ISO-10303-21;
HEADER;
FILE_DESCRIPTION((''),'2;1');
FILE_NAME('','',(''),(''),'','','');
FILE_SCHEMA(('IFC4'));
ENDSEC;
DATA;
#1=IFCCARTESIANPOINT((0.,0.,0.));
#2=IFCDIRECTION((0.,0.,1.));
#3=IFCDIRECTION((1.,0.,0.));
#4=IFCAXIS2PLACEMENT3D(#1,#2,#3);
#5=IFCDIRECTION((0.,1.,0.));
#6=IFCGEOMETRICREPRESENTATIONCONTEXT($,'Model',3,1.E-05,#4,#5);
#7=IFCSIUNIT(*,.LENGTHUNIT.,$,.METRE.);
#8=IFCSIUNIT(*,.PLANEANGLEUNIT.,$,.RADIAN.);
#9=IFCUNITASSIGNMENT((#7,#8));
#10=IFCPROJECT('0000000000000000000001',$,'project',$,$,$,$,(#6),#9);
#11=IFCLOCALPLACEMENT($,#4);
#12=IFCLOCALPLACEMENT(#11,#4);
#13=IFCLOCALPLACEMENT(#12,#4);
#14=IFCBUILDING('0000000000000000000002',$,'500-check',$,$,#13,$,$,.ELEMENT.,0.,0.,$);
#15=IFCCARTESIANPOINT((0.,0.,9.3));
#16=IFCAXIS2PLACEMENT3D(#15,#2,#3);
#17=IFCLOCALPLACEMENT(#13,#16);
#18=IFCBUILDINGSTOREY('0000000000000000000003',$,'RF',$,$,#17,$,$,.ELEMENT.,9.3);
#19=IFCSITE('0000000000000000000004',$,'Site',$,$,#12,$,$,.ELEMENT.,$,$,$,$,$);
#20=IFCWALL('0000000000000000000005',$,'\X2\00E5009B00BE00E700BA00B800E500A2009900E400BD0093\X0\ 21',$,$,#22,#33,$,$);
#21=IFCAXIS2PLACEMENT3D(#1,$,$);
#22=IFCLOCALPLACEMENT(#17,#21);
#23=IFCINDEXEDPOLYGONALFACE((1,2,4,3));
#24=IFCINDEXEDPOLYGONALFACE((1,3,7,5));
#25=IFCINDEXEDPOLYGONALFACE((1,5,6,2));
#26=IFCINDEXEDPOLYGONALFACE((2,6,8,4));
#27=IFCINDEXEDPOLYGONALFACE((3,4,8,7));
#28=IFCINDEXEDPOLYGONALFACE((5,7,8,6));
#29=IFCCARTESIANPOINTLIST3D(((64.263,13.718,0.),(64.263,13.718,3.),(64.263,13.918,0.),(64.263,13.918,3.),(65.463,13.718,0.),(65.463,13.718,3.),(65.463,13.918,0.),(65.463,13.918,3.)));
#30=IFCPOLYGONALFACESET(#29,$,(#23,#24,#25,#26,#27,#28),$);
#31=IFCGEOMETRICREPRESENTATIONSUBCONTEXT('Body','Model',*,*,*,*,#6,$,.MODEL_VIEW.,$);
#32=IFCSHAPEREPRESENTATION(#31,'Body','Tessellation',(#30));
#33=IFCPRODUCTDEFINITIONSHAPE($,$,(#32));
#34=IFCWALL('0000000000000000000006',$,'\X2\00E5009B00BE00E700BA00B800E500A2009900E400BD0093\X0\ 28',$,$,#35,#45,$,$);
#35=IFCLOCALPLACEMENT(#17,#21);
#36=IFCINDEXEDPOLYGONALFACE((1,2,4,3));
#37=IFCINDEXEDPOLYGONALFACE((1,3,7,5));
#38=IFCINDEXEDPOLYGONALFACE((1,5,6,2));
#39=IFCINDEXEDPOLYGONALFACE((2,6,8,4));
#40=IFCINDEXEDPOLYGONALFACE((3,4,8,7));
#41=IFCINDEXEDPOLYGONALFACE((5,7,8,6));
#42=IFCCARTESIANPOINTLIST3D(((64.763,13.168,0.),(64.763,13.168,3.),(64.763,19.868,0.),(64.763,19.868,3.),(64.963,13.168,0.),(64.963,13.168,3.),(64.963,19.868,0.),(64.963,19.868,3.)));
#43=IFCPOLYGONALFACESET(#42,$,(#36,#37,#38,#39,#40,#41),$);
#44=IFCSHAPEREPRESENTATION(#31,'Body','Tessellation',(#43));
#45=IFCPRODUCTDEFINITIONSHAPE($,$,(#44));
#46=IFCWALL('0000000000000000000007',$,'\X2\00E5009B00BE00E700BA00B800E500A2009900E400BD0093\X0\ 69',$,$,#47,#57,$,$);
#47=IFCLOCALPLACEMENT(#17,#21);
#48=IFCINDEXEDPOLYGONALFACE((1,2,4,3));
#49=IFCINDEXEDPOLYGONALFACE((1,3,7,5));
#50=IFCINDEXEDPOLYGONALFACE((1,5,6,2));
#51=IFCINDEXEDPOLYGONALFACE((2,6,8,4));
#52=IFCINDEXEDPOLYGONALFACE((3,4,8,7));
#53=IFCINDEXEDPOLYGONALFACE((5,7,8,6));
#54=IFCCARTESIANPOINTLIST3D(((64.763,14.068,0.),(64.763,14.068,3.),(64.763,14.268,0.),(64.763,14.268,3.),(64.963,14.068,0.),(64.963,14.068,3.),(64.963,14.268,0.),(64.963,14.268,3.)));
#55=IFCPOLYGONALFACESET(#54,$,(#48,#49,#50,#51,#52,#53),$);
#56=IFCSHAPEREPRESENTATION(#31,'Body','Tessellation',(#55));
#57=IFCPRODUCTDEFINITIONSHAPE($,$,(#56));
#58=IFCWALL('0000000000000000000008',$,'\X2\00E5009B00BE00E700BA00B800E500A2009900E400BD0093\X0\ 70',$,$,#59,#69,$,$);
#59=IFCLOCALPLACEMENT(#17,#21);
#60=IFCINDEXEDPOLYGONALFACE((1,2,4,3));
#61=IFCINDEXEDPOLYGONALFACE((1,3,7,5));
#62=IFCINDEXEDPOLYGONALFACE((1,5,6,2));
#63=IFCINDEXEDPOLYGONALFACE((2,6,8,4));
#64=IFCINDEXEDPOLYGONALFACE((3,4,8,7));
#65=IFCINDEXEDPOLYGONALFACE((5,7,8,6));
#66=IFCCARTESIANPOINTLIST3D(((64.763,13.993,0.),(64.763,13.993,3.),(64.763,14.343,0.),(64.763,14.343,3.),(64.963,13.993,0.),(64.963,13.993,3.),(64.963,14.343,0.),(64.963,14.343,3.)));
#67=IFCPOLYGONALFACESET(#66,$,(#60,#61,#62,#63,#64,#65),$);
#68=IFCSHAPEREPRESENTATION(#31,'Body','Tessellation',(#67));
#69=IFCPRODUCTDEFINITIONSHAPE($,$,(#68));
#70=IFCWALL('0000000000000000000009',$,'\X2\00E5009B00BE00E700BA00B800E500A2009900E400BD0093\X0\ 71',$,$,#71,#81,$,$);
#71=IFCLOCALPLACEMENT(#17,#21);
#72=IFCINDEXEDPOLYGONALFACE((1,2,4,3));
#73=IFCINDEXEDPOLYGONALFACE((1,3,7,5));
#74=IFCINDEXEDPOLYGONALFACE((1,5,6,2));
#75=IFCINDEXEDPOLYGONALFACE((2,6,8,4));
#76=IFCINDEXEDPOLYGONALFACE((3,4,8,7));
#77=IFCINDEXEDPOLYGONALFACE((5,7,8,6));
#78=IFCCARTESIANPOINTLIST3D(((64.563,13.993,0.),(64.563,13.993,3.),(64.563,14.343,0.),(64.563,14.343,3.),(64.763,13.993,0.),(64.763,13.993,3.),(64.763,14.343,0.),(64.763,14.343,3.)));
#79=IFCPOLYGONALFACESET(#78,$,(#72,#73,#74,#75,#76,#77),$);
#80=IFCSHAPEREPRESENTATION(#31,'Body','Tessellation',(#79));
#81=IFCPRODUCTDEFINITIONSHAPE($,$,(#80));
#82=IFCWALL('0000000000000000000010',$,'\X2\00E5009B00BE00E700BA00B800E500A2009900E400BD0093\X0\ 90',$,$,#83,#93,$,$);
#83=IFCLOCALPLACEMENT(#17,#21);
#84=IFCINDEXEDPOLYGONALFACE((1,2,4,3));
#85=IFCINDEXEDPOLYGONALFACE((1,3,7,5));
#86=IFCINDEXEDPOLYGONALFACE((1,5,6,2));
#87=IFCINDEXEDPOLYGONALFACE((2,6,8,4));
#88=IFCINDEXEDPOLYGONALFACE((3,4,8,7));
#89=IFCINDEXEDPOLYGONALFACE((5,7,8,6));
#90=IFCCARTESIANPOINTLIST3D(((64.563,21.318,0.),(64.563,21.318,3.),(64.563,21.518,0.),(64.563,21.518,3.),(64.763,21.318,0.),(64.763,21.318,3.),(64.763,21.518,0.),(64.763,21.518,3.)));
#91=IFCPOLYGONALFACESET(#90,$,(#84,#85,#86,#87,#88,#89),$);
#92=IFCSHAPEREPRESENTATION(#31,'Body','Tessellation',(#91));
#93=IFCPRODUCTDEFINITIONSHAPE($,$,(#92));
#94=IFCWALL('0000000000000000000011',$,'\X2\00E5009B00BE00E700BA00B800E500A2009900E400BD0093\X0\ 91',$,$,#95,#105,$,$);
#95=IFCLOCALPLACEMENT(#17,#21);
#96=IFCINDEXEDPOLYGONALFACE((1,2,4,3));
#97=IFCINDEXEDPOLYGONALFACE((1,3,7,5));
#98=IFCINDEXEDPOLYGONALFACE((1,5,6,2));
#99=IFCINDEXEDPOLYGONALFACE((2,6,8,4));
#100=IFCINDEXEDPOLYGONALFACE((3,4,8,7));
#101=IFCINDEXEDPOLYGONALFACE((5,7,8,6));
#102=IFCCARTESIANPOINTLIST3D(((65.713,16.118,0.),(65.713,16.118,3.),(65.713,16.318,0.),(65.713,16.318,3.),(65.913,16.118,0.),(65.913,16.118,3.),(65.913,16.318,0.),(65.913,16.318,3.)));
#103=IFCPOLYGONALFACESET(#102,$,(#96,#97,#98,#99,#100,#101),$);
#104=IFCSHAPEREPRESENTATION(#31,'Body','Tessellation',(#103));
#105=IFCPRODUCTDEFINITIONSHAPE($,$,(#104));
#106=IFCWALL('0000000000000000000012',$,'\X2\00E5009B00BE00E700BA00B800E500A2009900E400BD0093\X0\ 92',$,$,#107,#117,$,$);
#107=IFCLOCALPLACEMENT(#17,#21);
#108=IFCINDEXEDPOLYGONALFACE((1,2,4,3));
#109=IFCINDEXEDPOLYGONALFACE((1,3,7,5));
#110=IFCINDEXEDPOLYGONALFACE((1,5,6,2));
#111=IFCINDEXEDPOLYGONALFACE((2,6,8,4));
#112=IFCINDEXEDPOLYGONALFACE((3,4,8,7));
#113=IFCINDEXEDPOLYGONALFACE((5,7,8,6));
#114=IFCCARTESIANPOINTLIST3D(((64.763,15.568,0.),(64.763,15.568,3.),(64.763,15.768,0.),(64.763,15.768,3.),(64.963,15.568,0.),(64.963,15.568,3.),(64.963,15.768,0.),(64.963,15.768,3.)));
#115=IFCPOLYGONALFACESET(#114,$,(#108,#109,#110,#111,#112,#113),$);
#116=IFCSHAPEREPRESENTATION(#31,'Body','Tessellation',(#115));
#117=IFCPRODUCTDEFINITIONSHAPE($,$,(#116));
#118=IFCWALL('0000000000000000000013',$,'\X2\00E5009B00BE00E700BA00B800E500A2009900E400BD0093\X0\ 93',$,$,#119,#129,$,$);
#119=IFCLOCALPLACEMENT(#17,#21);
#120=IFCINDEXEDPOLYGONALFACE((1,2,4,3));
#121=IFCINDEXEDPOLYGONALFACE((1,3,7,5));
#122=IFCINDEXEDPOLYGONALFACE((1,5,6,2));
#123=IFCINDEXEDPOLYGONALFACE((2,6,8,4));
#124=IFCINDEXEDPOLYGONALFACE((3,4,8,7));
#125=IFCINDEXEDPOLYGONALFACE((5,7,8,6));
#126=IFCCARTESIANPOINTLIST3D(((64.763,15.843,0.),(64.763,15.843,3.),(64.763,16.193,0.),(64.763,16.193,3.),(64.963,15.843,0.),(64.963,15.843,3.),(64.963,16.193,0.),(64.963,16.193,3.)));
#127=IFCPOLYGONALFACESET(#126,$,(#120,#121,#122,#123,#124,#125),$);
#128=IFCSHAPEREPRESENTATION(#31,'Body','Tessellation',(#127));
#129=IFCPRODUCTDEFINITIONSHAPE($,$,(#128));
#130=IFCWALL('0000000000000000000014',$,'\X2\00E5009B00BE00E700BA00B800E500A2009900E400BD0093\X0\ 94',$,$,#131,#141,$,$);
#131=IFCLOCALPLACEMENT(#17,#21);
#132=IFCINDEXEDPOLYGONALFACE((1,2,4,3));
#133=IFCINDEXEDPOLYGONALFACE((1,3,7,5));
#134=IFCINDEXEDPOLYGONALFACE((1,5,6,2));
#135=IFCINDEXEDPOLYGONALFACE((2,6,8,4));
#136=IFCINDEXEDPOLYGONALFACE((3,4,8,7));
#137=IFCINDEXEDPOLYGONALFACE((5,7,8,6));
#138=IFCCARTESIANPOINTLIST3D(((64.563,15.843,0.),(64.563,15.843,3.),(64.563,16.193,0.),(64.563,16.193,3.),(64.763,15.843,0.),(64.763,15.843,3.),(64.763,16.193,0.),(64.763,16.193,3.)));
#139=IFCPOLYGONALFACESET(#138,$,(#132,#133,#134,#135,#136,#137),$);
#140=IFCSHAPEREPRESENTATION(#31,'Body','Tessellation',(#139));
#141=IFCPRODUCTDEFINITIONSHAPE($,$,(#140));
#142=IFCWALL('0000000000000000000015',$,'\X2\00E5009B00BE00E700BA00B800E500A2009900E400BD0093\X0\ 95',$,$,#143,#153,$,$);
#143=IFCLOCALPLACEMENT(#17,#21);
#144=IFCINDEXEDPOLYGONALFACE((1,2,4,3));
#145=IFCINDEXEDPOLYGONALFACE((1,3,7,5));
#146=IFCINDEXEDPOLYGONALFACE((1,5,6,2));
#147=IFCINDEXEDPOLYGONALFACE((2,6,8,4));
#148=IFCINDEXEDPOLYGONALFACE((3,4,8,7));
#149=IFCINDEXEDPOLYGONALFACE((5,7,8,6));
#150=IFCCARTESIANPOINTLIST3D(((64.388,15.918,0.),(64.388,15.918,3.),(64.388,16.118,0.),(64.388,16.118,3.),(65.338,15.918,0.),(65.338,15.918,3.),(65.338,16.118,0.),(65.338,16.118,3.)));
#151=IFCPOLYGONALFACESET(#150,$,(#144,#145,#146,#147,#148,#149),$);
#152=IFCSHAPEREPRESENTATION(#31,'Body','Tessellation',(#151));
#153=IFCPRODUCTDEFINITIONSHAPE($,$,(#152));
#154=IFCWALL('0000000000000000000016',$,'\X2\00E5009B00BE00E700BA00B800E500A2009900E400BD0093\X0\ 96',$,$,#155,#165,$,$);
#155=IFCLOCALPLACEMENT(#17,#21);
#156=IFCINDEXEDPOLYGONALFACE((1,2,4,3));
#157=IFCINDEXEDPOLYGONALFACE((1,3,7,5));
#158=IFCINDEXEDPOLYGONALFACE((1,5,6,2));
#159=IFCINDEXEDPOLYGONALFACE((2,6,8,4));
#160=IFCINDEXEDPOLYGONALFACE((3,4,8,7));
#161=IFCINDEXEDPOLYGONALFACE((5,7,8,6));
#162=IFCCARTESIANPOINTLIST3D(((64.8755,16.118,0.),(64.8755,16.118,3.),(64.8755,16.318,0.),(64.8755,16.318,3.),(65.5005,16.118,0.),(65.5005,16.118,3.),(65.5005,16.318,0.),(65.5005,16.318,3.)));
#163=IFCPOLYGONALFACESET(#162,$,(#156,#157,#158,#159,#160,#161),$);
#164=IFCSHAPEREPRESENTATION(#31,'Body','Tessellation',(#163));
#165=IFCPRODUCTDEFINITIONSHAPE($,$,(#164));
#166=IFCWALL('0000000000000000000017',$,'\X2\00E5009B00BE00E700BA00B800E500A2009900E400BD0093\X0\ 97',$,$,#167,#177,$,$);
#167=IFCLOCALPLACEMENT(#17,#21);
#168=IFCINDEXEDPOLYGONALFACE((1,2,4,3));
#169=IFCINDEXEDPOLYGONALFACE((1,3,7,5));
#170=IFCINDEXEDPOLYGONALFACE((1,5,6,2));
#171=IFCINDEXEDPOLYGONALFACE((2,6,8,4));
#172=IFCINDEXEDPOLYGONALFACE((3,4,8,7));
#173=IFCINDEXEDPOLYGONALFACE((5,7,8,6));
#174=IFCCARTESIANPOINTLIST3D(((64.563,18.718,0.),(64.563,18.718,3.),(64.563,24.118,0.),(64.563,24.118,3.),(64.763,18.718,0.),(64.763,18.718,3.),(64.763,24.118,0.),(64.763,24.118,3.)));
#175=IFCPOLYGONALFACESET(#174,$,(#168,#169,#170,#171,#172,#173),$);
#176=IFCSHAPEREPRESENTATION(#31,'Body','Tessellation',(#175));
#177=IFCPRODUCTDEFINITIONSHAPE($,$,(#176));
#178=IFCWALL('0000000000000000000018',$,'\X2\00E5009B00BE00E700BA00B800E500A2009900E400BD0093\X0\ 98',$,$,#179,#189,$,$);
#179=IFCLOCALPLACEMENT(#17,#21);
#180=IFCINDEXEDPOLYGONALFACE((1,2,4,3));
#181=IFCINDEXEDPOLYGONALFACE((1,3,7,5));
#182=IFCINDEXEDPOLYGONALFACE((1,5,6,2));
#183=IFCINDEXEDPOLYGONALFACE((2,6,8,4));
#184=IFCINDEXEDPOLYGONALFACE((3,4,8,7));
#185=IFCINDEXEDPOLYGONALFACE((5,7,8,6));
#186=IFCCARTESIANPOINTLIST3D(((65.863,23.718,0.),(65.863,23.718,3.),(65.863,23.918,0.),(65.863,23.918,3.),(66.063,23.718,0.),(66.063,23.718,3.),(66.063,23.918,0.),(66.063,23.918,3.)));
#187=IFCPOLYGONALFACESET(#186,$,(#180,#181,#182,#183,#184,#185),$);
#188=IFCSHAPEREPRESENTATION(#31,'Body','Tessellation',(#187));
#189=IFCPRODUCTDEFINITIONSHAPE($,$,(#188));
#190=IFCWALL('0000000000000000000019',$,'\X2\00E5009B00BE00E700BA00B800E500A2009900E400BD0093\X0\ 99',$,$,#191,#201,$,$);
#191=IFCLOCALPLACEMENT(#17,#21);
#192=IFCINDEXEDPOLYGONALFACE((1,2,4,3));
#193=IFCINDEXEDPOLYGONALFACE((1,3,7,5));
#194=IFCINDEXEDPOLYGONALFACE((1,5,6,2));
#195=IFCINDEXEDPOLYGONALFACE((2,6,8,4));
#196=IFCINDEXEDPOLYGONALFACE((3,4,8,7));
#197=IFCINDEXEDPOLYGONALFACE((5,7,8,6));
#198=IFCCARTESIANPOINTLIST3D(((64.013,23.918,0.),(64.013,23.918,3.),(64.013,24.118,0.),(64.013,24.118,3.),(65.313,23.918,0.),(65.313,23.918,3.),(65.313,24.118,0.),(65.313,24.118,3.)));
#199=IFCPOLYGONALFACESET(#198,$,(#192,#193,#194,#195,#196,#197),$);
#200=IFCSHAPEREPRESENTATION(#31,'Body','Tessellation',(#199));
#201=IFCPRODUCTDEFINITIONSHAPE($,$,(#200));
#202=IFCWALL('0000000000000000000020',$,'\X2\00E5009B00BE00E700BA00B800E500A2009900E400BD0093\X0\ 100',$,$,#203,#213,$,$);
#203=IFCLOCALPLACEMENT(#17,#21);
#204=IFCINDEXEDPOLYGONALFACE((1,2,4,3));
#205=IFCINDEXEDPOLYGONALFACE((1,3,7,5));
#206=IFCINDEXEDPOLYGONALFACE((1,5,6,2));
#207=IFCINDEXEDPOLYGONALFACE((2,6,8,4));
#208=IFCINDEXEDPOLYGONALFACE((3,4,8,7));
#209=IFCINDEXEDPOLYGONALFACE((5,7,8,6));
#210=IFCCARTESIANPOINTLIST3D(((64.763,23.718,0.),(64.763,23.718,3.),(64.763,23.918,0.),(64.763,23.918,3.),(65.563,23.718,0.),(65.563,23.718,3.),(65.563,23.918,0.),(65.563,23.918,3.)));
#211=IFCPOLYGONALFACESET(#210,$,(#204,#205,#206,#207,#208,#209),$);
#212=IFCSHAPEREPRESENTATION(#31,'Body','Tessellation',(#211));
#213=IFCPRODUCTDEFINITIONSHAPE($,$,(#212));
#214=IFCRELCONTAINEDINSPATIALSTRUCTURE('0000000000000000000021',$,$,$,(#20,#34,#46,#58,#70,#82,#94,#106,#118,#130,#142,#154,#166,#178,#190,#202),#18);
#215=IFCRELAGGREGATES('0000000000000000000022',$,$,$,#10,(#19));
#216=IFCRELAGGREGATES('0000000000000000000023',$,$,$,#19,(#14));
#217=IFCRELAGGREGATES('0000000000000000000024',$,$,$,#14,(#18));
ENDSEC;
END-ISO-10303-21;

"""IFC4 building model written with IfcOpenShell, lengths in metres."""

from ifc_helpers import new_model, si_unit, direction, frame, frame_2d, origin_with_axes, place, context, subcontext, project, spatial, rectangle, extrude, element, save


model = new_model("IFC4")

# Units and contexts
model_context = context("Model", 3, precision=1e-05, world=origin_with_axes(), true_north=direction((0.0, 1.0, 0.0)))
body_context = subcontext(model_context, "Body", "Model", "MODEL_VIEW")
ifc_project = project(units=[si_unit("LENGTHUNIT", "METRE"), si_unit("PLANEANGLEUNIT", "RADIAN")], contexts=[model_context])

# Site, building, storey
placement = place(None, origin_with_axes())
site_placement = place(placement, origin_with_axes())
site = spatial("IfcSite", under=ifc_project, at=site_placement, Name="Site", CompositionType="ELEMENT")
building_placement = place(site_placement, origin_with_axes())
building = spatial("IfcBuilding", under=site, at=building_placement, Name="500-check", CompositionType="ELEMENT", ElevationOfRefHeight=0.0, ElevationOfTerrain=0.0)
storey_placement = place(building_placement, frame((0.0, 0.0, 9.3), z_axis=(0.0, 0.0, 1.0), x_axis=(1.0, 0.0, 0.0)))
storey = spatial("IfcBuildingStorey", under=building, at=storey_placement, Name="RF", CompositionType="ELEMENT", Elevation=9.3)

# Walls
wall_1_placement = place(storey_placement, frame((64.863, 13.818, 0.0), z_axis=(0.0, 0.0, 1.0), x_axis=(1.0, 0.0, 0.0)))
element("IfcWall", 1, at=wall_1_placement, inside=storey, Name="å\u009b¾çº¸å¢\u0099ä½\u0093 21", context=body_context, shape_type="SweptSolid", body=[
    extrude(rectangle(XDim=1.2, YDim=0.2, at=frame_2d((0.0, 0.0), x_axis=(1.0, 0.0, 0.0))), frame((0.0, 0.0, 0.0), z_axis=(0.0, 0.0, 1.0)), (0.0, 0.0, 1.0), 3.0),
])
wall_2_placement = place(storey_placement, frame((64.863, 16.518, 0.0), z_axis=(0.0, 0.0, 1.0), x_axis=(0.0, 1.0, 0.0)))
element("IfcWall", 2, at=wall_2_placement, inside=storey, Name="å\u009b¾çº¸å¢\u0099ä½\u0093 28", context=body_context, shape_type="SweptSolid", body=[
    extrude(rectangle(XDim=6.7, YDim=0.2, at=frame_2d((0.0, 0.0), x_axis=(1.0, 0.0, 0.0))), frame((0.0, 0.0, 0.0), z_axis=(0.0, 0.0, 1.0)), (0.0, 0.0, 1.0), 3.0),
])
wall_3_placement = place(storey_placement, frame((64.863, 14.168, 0.0), z_axis=(0.0, 0.0, 1.0), x_axis=(-1.0, 0.0, 0.0)))
element("IfcWall", 3, at=wall_3_placement, inside=storey, Name="å\u009b¾çº¸å¢\u0099ä½\u0093 69", context=body_context, shape_type="SweptSolid", body=[
    extrude(rectangle(XDim=0.2, YDim=0.2, at=frame_2d((0.0, 0.0), x_axis=(1.0, 0.0, 0.0))), frame((0.0, 0.0, 0.0), z_axis=(0.0, 0.0, 1.0)), (0.0, 0.0, 1.0), 3.0),
])
for number, where, z_axis, x_axis, name in (
    (4, (64.863, 14.168, 0.0), (0.0, 0.0, 1.0), (0.0, -1.0, 0.0), "å\u009b¾çº¸å¢\u0099ä½\u0093 70"),
    (5, (64.663, 14.168, 0.0), (0.0, 0.0, 1.0), (0.0, -1.0, 0.0), "å\u009b¾çº¸å¢\u0099ä½\u0093 71"),
):
    element("IfcWall", number, at=place(storey_placement, frame(where, z_axis=z_axis, x_axis=x_axis)), inside=storey, Name=name, context=body_context, shape_type="SweptSolid", body=[
        extrude(rectangle(XDim=0.35, YDim=0.2, at=frame_2d((0.0, 0.0), x_axis=(1.0, 0.0, 0.0))), frame((0.0, 0.0, 0.0), z_axis=(0.0, 0.0, 1.0)), (0.0, 0.0, 1.0), 3.0),
    ])
for number, where, z_axis, x_axis, name in (
    (6, (64.663, 21.418, 0.0), (0.0, 0.0, 1.0), (0.0, 1.0, 0.0), "å\u009b¾çº¸å¢\u0099ä½\u0093 90"),
    (7, (65.813, 16.218, 0.0), (0.0, 0.0, 1.0), (0.0, -1.0, 0.0), "å\u009b¾çº¸å¢\u0099ä½\u0093 91"),
    (8, (64.863, 15.668, 0.0), (0.0, 0.0, 1.0), (-1.0, 0.0, 0.0), "å\u009b¾çº¸å¢\u0099ä½\u0093 92"),
):
    element("IfcWall", number, at=place(storey_placement, frame(where, z_axis=z_axis, x_axis=x_axis)), inside=storey, Name=name, context=body_context, shape_type="SweptSolid", body=[
        extrude(rectangle(XDim=0.2, YDim=0.2, at=frame_2d((0.0, 0.0), x_axis=(1.0, 0.0, 0.0))), frame((0.0, 0.0, 0.0), z_axis=(0.0, 0.0, 1.0)), (0.0, 0.0, 1.0), 3.0),
    ])
for number, where, z_axis, x_axis, name in (
    (9, (64.863, 16.018, 0.0), (0.0, 0.0, 1.0), (0.0, -1.0, 0.0), "å\u009b¾çº¸å¢\u0099ä½\u0093 93"),
    (10, (64.663, 16.018, 0.0), (0.0, 0.0, 1.0), (0.0, -1.0, 0.0), "å\u009b¾çº¸å¢\u0099ä½\u0093 94"),
):
    element("IfcWall", number, at=place(storey_placement, frame(where, z_axis=z_axis, x_axis=x_axis)), inside=storey, Name=name, context=body_context, shape_type="SweptSolid", body=[
        extrude(rectangle(XDim=0.35, YDim=0.2, at=frame_2d((0.0, 0.0), x_axis=(1.0, 0.0, 0.0))), frame((0.0, 0.0, 0.0), z_axis=(0.0, 0.0, 1.0)), (0.0, 0.0, 1.0), 3.0),
    ])
wall_4_placement = place(storey_placement, frame((64.863, 16.018, 0.0), z_axis=(0.0, 0.0, 1.0), x_axis=(1.0, 0.0, 0.0)))
element("IfcWall", 11, at=wall_4_placement, inside=storey, Name="å\u009b¾çº¸å¢\u0099ä½\u0093 95", context=body_context, shape_type="SweptSolid", body=[
    extrude(rectangle(XDim=0.95, YDim=0.2, at=frame_2d((0.0, 0.0), x_axis=(1.0, 0.0, 0.0))), frame((0.0, 0.0, 0.0), z_axis=(0.0, 0.0, 1.0)), (0.0, 0.0, 1.0), 3.0),
])
wall_5_placement = place(storey_placement, frame((65.188, 16.218, 0.0), z_axis=(0.0, 0.0, 1.0), x_axis=(1.0, 0.0, 0.0)))
element("IfcWall", 12, at=wall_5_placement, inside=storey, Name="å\u009b¾çº¸å¢\u0099ä½\u0093 96", context=body_context, shape_type="SweptSolid", body=[
    extrude(rectangle(XDim=0.625, YDim=0.2, at=frame_2d((0.0, 0.0), x_axis=(1.0, 0.0, 0.0))), frame((0.0, 0.0, 0.0), z_axis=(0.0, 0.0, 1.0)), (0.0, 0.0, 1.0), 3.0),
])
wall_6_placement = place(storey_placement, frame((64.663, 21.418, 0.0), z_axis=(0.0, 0.0, 1.0), x_axis=(0.0, -1.0, 0.0)))
element("IfcWall", 13, at=wall_6_placement, inside=storey, Name="å\u009b¾çº¸å¢\u0099ä½\u0093 97", context=body_context, shape_type="SweptSolid", body=[
    extrude(rectangle(XDim=5.4, YDim=0.2, at=frame_2d((0.0, 0.0), x_axis=(1.0, 0.0, 0.0))), frame((0.0, 0.0, 0.0), z_axis=(0.0, 0.0, 1.0)), (0.0, 0.0, 1.0), 3.0),
])
wall_7_placement = place(storey_placement, frame((65.963, 23.818, 0.0), z_axis=(0.0, 0.0, 1.0), x_axis=(0.0, 1.0, 0.0)))
element("IfcWall", 14, at=wall_7_placement, inside=storey, Name="å\u009b¾çº¸å¢\u0099ä½\u0093 98", context=body_context, shape_type="SweptSolid", body=[
    extrude(rectangle(XDim=0.2, YDim=0.2, at=frame_2d((0.0, 0.0), x_axis=(1.0, 0.0, 0.0))), frame((0.0, 0.0, 0.0), z_axis=(0.0, 0.0, 1.0)), (0.0, 0.0, 1.0), 3.0),
])
wall_8_placement = place(storey_placement, frame((64.663, 24.018, 0.0), z_axis=(0.0, 0.0, 1.0), x_axis=(1.0, 0.0, 0.0)))
element("IfcWall", 15, at=wall_8_placement, inside=storey, Name="å\u009b¾çº¸å¢\u0099ä½\u0093 99", context=body_context, shape_type="SweptSolid", body=[
    extrude(rectangle(XDim=1.3, YDim=0.2, at=frame_2d((0.0, 0.0), x_axis=(1.0, 0.0, 0.0))), frame((0.0, 0.0, 0.0), z_axis=(0.0, 0.0, 1.0)), (0.0, 0.0, 1.0), 3.0),
])
wall_9_placement = place(storey_placement, frame((65.163, 23.818, 0.0), z_axis=(0.0, 0.0, 1.0), x_axis=(1.0, 0.0, 0.0)))
element("IfcWall", 16, at=wall_9_placement, inside=storey, Name="å\u009b¾çº¸å¢\u0099ä½\u0093 100", context=body_context, shape_type="SweptSolid", body=[
    extrude(rectangle(XDim=0.8, YDim=0.2, at=frame_2d((0.0, 0.0), x_axis=(1.0, 0.0, 0.0))), frame((0.0, 0.0, 0.0), z_axis=(0.0, 0.0, 1.0)), (0.0, 0.0, 1.0), 3.0),
])

save(model, "model.ifc")
